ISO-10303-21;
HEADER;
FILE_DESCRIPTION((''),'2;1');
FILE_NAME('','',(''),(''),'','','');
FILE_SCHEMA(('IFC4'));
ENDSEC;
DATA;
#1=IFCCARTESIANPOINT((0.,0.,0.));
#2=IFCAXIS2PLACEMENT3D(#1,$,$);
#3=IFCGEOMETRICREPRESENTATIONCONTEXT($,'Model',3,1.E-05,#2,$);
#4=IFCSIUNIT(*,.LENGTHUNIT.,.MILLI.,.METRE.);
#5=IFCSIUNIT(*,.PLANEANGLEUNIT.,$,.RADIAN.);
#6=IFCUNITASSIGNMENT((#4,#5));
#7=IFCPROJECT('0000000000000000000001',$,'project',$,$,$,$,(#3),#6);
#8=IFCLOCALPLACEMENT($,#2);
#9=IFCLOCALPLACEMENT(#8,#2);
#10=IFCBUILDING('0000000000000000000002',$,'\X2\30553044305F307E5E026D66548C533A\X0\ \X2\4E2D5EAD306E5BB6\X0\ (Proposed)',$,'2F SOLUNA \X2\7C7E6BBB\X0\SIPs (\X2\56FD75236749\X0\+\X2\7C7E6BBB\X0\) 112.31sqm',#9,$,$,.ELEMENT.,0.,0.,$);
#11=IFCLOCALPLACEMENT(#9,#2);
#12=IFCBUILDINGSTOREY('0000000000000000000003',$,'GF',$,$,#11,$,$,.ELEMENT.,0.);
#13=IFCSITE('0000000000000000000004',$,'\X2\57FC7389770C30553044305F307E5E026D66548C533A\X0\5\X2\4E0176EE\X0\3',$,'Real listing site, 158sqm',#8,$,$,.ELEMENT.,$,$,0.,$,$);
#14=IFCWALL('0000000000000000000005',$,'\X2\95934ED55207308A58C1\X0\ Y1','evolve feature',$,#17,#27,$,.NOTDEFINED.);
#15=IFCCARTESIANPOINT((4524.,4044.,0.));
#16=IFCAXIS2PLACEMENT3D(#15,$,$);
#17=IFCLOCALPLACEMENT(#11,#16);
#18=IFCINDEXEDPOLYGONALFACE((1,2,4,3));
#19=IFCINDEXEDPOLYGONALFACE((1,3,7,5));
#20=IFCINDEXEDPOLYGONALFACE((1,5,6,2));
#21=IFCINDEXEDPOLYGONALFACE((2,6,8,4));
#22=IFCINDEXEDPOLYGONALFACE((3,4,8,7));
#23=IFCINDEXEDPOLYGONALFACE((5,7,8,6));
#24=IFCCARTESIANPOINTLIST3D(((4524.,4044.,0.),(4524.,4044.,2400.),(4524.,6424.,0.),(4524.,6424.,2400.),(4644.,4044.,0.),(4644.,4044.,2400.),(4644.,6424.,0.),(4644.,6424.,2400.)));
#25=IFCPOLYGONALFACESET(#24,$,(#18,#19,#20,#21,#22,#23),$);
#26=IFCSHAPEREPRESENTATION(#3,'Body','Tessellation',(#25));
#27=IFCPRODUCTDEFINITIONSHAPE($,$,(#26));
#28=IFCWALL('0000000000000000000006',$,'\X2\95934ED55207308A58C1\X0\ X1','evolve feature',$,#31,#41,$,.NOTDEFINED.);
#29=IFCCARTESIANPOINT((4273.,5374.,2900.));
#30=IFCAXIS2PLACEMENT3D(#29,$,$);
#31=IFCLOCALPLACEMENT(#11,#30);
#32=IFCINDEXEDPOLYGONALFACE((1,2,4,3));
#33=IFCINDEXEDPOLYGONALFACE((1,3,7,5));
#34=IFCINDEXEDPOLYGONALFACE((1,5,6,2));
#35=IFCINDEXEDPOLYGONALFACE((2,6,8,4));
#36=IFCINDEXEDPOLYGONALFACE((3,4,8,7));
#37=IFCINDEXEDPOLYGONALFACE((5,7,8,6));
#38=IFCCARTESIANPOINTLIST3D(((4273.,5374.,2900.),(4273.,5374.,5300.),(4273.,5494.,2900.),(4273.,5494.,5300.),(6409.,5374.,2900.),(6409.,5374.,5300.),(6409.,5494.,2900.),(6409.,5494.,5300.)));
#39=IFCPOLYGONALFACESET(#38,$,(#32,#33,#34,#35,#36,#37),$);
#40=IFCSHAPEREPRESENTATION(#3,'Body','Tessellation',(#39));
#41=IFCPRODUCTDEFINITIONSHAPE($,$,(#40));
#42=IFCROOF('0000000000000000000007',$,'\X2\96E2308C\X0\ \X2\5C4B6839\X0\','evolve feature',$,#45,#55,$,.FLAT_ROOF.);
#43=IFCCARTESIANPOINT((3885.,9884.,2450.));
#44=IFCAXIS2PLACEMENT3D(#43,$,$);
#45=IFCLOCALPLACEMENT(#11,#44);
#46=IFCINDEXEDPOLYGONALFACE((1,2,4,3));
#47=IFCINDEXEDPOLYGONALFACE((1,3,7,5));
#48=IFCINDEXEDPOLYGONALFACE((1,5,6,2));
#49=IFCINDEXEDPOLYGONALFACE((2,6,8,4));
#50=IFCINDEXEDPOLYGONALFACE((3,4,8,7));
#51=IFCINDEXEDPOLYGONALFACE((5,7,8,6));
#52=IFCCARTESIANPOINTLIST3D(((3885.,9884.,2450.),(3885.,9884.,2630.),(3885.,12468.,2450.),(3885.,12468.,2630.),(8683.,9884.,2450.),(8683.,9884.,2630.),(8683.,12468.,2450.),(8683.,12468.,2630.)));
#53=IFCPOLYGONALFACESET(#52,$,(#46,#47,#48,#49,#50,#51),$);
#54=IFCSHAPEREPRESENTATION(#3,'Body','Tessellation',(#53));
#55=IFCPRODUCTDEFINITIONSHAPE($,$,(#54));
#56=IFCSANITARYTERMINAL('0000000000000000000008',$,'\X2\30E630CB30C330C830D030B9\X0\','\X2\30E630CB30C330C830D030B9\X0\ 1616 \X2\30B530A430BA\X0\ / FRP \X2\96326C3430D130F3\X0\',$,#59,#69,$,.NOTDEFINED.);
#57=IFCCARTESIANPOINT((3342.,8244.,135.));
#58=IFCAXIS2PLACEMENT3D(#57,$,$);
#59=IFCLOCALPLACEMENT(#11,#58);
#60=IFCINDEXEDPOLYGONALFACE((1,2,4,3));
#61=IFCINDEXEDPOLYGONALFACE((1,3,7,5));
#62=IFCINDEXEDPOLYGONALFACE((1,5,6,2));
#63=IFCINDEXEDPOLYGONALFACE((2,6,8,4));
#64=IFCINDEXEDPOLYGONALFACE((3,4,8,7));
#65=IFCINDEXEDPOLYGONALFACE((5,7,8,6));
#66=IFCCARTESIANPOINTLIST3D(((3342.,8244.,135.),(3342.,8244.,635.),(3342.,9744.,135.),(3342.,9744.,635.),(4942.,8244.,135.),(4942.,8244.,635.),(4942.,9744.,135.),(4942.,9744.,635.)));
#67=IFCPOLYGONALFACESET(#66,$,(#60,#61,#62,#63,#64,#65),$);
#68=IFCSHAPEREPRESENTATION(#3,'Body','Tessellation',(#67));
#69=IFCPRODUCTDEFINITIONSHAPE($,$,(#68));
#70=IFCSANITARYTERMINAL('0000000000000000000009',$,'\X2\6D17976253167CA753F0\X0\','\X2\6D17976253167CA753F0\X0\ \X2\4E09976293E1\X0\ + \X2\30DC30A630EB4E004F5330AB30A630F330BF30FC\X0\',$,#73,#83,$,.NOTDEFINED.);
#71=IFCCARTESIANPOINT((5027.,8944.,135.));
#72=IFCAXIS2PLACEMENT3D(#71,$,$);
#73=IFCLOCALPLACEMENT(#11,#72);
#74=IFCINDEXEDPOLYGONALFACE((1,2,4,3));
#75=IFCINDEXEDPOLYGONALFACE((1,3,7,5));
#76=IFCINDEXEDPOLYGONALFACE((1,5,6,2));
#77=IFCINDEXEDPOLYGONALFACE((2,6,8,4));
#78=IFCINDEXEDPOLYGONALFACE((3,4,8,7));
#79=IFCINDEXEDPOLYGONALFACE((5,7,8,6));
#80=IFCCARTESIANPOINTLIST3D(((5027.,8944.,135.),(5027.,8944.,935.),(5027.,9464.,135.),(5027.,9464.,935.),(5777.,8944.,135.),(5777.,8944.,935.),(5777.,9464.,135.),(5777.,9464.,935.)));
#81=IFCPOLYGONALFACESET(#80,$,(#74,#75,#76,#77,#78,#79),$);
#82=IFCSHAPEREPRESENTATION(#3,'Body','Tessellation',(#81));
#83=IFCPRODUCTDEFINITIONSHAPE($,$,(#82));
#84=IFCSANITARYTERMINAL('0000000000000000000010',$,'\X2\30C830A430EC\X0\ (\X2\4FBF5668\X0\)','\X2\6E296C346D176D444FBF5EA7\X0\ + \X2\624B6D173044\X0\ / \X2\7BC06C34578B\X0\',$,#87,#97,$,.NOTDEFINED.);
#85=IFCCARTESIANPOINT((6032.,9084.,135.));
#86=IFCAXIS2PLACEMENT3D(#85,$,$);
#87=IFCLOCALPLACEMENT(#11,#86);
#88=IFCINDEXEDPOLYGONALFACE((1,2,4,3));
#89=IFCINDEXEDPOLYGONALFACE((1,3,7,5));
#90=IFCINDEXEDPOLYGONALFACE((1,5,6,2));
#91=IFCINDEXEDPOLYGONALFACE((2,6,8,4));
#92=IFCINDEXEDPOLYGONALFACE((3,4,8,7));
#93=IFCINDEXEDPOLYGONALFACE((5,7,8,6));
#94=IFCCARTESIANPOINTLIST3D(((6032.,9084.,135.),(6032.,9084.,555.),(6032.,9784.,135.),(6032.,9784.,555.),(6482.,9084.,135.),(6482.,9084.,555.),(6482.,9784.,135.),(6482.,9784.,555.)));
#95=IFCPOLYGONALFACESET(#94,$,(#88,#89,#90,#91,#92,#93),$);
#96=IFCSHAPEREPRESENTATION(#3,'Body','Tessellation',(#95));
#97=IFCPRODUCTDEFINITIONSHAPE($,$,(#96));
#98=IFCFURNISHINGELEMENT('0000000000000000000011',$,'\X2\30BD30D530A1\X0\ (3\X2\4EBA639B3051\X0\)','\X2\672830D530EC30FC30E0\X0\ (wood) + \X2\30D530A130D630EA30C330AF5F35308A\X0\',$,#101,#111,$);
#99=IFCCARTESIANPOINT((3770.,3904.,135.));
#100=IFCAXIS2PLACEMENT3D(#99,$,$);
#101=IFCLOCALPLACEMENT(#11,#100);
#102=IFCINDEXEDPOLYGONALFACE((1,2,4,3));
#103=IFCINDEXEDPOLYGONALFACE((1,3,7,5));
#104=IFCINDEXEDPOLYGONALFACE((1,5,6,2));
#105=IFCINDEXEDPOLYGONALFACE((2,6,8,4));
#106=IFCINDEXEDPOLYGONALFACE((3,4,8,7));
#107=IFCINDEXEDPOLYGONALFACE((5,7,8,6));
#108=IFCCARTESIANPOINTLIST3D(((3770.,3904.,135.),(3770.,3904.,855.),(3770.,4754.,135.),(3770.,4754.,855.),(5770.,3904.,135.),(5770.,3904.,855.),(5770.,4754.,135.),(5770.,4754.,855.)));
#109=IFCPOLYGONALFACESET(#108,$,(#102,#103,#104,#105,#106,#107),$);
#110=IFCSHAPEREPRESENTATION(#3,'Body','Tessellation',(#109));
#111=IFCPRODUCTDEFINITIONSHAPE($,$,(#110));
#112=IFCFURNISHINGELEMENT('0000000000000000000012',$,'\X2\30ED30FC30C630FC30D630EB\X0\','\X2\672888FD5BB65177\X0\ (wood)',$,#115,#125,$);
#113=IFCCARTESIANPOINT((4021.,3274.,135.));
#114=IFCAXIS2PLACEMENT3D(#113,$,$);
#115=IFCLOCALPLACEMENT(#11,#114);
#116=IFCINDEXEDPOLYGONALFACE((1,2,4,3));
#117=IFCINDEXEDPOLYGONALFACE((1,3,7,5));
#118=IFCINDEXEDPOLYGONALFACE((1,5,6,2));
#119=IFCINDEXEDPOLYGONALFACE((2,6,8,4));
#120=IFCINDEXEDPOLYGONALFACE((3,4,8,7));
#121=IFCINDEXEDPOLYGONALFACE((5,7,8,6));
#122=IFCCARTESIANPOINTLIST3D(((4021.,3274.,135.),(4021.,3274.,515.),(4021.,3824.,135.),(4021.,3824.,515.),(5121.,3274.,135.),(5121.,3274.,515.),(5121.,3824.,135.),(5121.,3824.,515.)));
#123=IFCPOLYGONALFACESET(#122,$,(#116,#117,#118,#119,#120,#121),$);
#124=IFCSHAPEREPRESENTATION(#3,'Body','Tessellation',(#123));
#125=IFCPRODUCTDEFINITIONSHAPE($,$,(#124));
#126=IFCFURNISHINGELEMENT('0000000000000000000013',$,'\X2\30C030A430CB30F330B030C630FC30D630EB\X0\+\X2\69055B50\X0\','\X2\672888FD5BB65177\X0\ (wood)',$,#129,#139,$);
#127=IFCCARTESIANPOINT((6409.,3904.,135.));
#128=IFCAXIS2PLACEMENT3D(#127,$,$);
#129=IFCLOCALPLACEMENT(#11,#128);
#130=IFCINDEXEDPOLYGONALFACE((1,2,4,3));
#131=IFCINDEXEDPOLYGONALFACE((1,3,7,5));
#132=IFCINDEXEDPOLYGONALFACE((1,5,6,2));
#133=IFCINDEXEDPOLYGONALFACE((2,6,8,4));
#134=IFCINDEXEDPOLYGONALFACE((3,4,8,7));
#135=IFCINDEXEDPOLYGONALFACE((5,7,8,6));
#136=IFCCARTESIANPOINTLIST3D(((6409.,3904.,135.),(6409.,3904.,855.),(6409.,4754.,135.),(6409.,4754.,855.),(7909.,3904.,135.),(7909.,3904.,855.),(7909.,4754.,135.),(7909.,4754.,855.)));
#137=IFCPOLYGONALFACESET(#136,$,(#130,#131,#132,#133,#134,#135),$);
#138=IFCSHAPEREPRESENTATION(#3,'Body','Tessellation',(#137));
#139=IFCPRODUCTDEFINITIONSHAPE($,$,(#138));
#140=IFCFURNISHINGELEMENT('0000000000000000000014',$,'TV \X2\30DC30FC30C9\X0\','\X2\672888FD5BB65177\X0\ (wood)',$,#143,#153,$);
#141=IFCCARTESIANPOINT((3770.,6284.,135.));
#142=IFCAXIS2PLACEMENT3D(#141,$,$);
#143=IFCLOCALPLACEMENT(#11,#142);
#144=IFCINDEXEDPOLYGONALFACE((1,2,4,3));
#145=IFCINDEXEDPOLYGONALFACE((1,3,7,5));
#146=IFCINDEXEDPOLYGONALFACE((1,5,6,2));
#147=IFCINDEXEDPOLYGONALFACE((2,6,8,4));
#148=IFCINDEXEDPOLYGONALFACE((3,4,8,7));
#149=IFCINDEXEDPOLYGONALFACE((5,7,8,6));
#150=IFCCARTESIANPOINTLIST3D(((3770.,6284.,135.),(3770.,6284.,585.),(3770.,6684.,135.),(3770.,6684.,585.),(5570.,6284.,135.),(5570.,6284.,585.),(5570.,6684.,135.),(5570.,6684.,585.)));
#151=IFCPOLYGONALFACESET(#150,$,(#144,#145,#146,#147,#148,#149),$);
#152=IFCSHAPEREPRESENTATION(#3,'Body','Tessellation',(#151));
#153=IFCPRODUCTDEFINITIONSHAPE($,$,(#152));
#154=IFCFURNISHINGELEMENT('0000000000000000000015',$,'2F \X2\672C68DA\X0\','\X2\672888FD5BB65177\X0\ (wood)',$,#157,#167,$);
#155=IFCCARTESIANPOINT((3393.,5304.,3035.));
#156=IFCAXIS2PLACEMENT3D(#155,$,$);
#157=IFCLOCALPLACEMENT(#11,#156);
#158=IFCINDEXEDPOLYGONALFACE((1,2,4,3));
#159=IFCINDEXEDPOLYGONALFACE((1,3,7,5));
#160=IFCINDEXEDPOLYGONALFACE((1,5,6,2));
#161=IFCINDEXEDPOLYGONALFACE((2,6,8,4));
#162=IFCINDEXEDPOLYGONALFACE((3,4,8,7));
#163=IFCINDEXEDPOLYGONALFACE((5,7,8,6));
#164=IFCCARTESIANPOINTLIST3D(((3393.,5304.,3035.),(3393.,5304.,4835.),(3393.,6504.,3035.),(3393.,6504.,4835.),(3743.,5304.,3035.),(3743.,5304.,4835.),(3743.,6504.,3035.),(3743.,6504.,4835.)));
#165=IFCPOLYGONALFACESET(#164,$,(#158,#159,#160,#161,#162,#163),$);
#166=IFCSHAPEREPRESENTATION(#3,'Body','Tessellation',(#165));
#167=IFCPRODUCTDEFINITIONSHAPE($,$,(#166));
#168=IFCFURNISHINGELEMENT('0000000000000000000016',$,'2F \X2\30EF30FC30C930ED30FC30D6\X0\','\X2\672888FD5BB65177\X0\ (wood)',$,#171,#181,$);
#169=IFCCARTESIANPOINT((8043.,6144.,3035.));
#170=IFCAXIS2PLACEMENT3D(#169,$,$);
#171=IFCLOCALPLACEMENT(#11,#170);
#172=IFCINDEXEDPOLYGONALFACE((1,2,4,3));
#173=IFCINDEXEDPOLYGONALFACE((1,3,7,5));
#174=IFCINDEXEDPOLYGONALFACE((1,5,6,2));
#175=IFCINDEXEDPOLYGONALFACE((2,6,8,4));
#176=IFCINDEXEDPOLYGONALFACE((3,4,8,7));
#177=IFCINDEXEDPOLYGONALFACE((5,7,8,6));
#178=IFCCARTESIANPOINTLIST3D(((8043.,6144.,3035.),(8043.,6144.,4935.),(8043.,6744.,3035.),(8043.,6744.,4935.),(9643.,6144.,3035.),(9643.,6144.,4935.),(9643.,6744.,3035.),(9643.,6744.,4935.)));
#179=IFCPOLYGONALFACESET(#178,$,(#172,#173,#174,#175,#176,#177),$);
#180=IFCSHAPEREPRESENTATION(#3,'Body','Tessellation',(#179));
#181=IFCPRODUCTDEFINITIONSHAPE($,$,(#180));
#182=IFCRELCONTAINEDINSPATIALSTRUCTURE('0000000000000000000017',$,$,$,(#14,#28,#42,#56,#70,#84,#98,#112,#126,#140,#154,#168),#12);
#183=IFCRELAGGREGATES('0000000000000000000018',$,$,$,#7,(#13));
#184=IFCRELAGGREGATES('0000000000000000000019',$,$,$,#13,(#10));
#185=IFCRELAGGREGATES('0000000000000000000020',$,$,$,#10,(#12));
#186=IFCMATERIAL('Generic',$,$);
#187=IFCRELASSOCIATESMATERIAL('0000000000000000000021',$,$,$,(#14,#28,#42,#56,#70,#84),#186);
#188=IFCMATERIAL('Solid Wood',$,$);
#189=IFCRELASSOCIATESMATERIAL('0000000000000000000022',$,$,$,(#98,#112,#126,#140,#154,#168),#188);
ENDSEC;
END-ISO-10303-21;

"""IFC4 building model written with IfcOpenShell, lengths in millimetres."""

from ifc_helpers import new_model, si_unit, frame, frame_2d, origin, place, context, project, spatial, rectangle, extrude, material, element, save


model = new_model("IFC4")

# Units and contexts
model_context = context("Model", 3, precision=1e-05, world=origin())
ifc_project = project(units=[si_unit("LENGTHUNIT", "METRE", prefix="MILLI"), si_unit("PLANEANGLEUNIT", "RADIAN")], contexts=[model_context])

# Site, building, storey
site_placement = place(None, origin())
site = spatial("IfcSite", under=ifc_project, at=site_placement, Name="埼玉県さいたま市浦和区5丁目3", ObjectType="Real listing site, 158sqm", CompositionType="ELEMENT", RefElevation=0.0)
building_placement = place(site_placement, origin())
building = spatial("IfcBuilding", under=site, at=building_placement, Name="さいたま市浦和区 中庭の家 (Proposed)", ObjectType="2F SOLUNA 籾殻SIPs (国産杉+籾殻) 112.31sqm", CompositionType="ELEMENT", ElevationOfRefHeight=0.0, ElevationOfTerrain=0.0)
storey_placement = place(building_placement, origin())
storey = spatial("IfcBuildingStorey", under=building, at=storey_placement, Name="GF", CompositionType="ELEMENT", Elevation=0.0)

# Shared definitions
ifc_material_1 = material(Name="Generic")

# Shared definitions
ifc_material_2 = material(Name="Solid Wood")

# Walls
wall_1_placement = place(storey_placement, frame((4524.0, 4044.0, 0.0)))
element("IfcWall", 1, at=wall_1_placement, inside=storey, material=ifc_material_1, Name="間仕切り壁 Y1", Description="evolve feature", PredefinedType="NOTDEFINED", context=model_context, shape_type="SweptSolid", body=[
    extrude(rectangle(XDim=120.0, YDim=2380.0, at=frame_2d((60.0, 1190.0))), frame((4524.0, 4044.0, 0.0)), (0.0, 0.0, 1.0), 2400.0),
])
wall_2_placement = place(storey_placement, frame((4273.0, 5374.0, 2900.0)))
element("IfcWall", 2, at=wall_2_placement, inside=storey, material=ifc_material_1, Name="間仕切り壁 X1", Description="evolve feature", PredefinedType="NOTDEFINED", context=model_context, shape_type="SweptSolid", body=[
    extrude(rectangle(XDim=2136.0, YDim=120.0, at=frame_2d((1068.0, 60.0))), frame((4273.0, 5374.0, 2900.0)), (0.0, 0.0, 1.0), 2400.0),
])

# Roof
roof_placement = place(storey_placement, frame((3885.0, 9884.0, 2450.0)))
element("IfcRoof", 3, at=roof_placement, inside=storey, material=ifc_material_1, Name="離れ 屋根", Description="evolve feature", PredefinedType="FLAT_ROOF", context=model_context, shape_type="SweptSolid", body=[
    extrude(rectangle(XDim=4798.0, YDim=2584.0, at=frame_2d((2399.0, 1292.0))), frame((3885.0, 9884.0, 2450.0)), (0.0, 0.0, 1.0), 180.0),
])

# Sanitary terminals
sanitary_terminal_1_placement = place(storey_placement, frame((3342.0, 8244.0, 135.0)))
element("IfcSanitaryTerminal", 4, at=sanitary_terminal_1_placement, inside=storey, material=ifc_material_1, Name="ユニットバス", Description="ユニットバス 1616 サイズ / FRP 防水パン", PredefinedType="NOTDEFINED", context=model_context, shape_type="SweptSolid", body=[
    extrude(rectangle(XDim=1600.0, YDim=1500.0, at=frame_2d((800.0, 750.0))), frame((3342.0, 8244.0, 135.0)), (0.0, 0.0, 1.0), 500.0),
])
sanitary_terminal_2_placement = place(storey_placement, frame((5027.0, 8944.0, 135.0)))
element("IfcSanitaryTerminal", 5, at=sanitary_terminal_2_placement, inside=storey, material=ifc_material_1, Name="洗面化粧台", Description="洗面化粧台 三面鏡 + ボウル一体カウンター", PredefinedType="NOTDEFINED", context=model_context, shape_type="SweptSolid", body=[
    extrude(rectangle(XDim=750.0, YDim=520.0, at=frame_2d((375.0, 260.0))), frame((5027.0, 8944.0, 135.0)), (0.0, 0.0, 1.0), 800.0),
])
sanitary_terminal_3_placement = place(storey_placement, frame((6032.0, 9084.0, 135.0)))
element("IfcSanitaryTerminal", 6, at=sanitary_terminal_3_placement, inside=storey, material=ifc_material_1, Name="トイレ (便器)", Description="温水洗浄便座 + 手洗い / 節水型", PredefinedType="NOTDEFINED", context=model_context, shape_type="SweptSolid", body=[
    extrude(rectangle(XDim=450.0, YDim=700.0, at=frame_2d((225.0, 350.0))), frame((6032.0, 9084.0, 135.0)), (0.0, 0.0, 1.0), 420.0),
])

# Furnishing elements
furnishing_1_placement = place(storey_placement, frame((3770.0, 3904.0, 135.0)))
element("IfcFurnishingElement", 7, at=furnishing_1_placement, inside=storey, material=ifc_material_2, Name="ソファ (3人掛け)", Description="木フレーム (wood) + ファブリック張り", context=model_context, shape_type="SweptSolid", body=[
    extrude(rectangle(XDim=2000.0, YDim=850.0, at=frame_2d((1000.0, 425.0))), frame((3770.0, 3904.0, 135.0)), (0.0, 0.0, 1.0), 720.0),
])
furnishing_2_placement = place(storey_placement, frame((4021.0, 3274.0, 135.0)))
element("IfcFurnishingElement", 8, at=furnishing_2_placement, inside=storey, material=ifc_material_2, Name="ローテーブル", Description="木製家具 (wood)", context=model_context, shape_type="SweptSolid", body=[
    extrude(rectangle(XDim=1100.0, YDim=550.0, at=frame_2d((550.0, 275.0))), frame((4021.0, 3274.0, 135.0)), (0.0, 0.0, 1.0), 380.0),
])
furnishing_3_placement = place(storey_placement, frame((6409.0, 3904.0, 135.0)))
element("IfcFurnishingElement", 9, at=furnishing_3_placement, inside=storey, material=ifc_material_2, Name="ダイニングテーブル+椅子", Description="木製家具 (wood)", context=model_context, shape_type="SweptSolid", body=[
    extrude(rectangle(XDim=1500.0, YDim=850.0, at=frame_2d((750.0, 425.0))), frame((6409.0, 3904.0, 135.0)), (0.0, 0.0, 1.0), 720.0),
])
furnishing_4_placement = place(storey_placement, frame((3770.0, 6284.0, 135.0)))
element("IfcFurnishingElement", 10, at=furnishing_4_placement, inside=storey, material=ifc_material_2, Name="TV ボード", Description="木製家具 (wood)", context=model_context, shape_type="SweptSolid", body=[
    extrude(rectangle(XDim=1800.0, YDim=400.0, at=frame_2d((900.0, 200.0))), frame((3770.0, 6284.0, 135.0)), (0.0, 0.0, 1.0), 450.0),
])
furnishing_5_placement = place(storey_placement, frame((3393.0, 5304.0, 3035.0)))
element("IfcFurnishingElement", 11, at=furnishing_5_placement, inside=storey, material=ifc_material_2, Name="2F 本棚", Description="木製家具 (wood)", context=model_context, shape_type="SweptSolid", body=[
    extrude(rectangle(XDim=350.0, YDim=1200.0, at=frame_2d((175.0, 600.0))), frame((3393.0, 5304.0, 3035.0)), (0.0, 0.0, 1.0), 1800.0),
])
furnishing_6_placement = place(storey_placement, frame((8043.0, 6144.0, 3035.0)))
element("IfcFurnishingElement", 12, at=furnishing_6_placement, inside=storey, material=ifc_material_2, Name="2F ワードローブ", Description="木製家具 (wood)", context=model_context, shape_type="SweptSolid", body=[
    extrude(rectangle(XDim=1600.0, YDim=600.0, at=frame_2d((800.0, 300.0))), frame((8043.0, 6144.0, 3035.0)), (0.0, 0.0, 1.0), 1900.0),
])

save(model, "model.ifc")
